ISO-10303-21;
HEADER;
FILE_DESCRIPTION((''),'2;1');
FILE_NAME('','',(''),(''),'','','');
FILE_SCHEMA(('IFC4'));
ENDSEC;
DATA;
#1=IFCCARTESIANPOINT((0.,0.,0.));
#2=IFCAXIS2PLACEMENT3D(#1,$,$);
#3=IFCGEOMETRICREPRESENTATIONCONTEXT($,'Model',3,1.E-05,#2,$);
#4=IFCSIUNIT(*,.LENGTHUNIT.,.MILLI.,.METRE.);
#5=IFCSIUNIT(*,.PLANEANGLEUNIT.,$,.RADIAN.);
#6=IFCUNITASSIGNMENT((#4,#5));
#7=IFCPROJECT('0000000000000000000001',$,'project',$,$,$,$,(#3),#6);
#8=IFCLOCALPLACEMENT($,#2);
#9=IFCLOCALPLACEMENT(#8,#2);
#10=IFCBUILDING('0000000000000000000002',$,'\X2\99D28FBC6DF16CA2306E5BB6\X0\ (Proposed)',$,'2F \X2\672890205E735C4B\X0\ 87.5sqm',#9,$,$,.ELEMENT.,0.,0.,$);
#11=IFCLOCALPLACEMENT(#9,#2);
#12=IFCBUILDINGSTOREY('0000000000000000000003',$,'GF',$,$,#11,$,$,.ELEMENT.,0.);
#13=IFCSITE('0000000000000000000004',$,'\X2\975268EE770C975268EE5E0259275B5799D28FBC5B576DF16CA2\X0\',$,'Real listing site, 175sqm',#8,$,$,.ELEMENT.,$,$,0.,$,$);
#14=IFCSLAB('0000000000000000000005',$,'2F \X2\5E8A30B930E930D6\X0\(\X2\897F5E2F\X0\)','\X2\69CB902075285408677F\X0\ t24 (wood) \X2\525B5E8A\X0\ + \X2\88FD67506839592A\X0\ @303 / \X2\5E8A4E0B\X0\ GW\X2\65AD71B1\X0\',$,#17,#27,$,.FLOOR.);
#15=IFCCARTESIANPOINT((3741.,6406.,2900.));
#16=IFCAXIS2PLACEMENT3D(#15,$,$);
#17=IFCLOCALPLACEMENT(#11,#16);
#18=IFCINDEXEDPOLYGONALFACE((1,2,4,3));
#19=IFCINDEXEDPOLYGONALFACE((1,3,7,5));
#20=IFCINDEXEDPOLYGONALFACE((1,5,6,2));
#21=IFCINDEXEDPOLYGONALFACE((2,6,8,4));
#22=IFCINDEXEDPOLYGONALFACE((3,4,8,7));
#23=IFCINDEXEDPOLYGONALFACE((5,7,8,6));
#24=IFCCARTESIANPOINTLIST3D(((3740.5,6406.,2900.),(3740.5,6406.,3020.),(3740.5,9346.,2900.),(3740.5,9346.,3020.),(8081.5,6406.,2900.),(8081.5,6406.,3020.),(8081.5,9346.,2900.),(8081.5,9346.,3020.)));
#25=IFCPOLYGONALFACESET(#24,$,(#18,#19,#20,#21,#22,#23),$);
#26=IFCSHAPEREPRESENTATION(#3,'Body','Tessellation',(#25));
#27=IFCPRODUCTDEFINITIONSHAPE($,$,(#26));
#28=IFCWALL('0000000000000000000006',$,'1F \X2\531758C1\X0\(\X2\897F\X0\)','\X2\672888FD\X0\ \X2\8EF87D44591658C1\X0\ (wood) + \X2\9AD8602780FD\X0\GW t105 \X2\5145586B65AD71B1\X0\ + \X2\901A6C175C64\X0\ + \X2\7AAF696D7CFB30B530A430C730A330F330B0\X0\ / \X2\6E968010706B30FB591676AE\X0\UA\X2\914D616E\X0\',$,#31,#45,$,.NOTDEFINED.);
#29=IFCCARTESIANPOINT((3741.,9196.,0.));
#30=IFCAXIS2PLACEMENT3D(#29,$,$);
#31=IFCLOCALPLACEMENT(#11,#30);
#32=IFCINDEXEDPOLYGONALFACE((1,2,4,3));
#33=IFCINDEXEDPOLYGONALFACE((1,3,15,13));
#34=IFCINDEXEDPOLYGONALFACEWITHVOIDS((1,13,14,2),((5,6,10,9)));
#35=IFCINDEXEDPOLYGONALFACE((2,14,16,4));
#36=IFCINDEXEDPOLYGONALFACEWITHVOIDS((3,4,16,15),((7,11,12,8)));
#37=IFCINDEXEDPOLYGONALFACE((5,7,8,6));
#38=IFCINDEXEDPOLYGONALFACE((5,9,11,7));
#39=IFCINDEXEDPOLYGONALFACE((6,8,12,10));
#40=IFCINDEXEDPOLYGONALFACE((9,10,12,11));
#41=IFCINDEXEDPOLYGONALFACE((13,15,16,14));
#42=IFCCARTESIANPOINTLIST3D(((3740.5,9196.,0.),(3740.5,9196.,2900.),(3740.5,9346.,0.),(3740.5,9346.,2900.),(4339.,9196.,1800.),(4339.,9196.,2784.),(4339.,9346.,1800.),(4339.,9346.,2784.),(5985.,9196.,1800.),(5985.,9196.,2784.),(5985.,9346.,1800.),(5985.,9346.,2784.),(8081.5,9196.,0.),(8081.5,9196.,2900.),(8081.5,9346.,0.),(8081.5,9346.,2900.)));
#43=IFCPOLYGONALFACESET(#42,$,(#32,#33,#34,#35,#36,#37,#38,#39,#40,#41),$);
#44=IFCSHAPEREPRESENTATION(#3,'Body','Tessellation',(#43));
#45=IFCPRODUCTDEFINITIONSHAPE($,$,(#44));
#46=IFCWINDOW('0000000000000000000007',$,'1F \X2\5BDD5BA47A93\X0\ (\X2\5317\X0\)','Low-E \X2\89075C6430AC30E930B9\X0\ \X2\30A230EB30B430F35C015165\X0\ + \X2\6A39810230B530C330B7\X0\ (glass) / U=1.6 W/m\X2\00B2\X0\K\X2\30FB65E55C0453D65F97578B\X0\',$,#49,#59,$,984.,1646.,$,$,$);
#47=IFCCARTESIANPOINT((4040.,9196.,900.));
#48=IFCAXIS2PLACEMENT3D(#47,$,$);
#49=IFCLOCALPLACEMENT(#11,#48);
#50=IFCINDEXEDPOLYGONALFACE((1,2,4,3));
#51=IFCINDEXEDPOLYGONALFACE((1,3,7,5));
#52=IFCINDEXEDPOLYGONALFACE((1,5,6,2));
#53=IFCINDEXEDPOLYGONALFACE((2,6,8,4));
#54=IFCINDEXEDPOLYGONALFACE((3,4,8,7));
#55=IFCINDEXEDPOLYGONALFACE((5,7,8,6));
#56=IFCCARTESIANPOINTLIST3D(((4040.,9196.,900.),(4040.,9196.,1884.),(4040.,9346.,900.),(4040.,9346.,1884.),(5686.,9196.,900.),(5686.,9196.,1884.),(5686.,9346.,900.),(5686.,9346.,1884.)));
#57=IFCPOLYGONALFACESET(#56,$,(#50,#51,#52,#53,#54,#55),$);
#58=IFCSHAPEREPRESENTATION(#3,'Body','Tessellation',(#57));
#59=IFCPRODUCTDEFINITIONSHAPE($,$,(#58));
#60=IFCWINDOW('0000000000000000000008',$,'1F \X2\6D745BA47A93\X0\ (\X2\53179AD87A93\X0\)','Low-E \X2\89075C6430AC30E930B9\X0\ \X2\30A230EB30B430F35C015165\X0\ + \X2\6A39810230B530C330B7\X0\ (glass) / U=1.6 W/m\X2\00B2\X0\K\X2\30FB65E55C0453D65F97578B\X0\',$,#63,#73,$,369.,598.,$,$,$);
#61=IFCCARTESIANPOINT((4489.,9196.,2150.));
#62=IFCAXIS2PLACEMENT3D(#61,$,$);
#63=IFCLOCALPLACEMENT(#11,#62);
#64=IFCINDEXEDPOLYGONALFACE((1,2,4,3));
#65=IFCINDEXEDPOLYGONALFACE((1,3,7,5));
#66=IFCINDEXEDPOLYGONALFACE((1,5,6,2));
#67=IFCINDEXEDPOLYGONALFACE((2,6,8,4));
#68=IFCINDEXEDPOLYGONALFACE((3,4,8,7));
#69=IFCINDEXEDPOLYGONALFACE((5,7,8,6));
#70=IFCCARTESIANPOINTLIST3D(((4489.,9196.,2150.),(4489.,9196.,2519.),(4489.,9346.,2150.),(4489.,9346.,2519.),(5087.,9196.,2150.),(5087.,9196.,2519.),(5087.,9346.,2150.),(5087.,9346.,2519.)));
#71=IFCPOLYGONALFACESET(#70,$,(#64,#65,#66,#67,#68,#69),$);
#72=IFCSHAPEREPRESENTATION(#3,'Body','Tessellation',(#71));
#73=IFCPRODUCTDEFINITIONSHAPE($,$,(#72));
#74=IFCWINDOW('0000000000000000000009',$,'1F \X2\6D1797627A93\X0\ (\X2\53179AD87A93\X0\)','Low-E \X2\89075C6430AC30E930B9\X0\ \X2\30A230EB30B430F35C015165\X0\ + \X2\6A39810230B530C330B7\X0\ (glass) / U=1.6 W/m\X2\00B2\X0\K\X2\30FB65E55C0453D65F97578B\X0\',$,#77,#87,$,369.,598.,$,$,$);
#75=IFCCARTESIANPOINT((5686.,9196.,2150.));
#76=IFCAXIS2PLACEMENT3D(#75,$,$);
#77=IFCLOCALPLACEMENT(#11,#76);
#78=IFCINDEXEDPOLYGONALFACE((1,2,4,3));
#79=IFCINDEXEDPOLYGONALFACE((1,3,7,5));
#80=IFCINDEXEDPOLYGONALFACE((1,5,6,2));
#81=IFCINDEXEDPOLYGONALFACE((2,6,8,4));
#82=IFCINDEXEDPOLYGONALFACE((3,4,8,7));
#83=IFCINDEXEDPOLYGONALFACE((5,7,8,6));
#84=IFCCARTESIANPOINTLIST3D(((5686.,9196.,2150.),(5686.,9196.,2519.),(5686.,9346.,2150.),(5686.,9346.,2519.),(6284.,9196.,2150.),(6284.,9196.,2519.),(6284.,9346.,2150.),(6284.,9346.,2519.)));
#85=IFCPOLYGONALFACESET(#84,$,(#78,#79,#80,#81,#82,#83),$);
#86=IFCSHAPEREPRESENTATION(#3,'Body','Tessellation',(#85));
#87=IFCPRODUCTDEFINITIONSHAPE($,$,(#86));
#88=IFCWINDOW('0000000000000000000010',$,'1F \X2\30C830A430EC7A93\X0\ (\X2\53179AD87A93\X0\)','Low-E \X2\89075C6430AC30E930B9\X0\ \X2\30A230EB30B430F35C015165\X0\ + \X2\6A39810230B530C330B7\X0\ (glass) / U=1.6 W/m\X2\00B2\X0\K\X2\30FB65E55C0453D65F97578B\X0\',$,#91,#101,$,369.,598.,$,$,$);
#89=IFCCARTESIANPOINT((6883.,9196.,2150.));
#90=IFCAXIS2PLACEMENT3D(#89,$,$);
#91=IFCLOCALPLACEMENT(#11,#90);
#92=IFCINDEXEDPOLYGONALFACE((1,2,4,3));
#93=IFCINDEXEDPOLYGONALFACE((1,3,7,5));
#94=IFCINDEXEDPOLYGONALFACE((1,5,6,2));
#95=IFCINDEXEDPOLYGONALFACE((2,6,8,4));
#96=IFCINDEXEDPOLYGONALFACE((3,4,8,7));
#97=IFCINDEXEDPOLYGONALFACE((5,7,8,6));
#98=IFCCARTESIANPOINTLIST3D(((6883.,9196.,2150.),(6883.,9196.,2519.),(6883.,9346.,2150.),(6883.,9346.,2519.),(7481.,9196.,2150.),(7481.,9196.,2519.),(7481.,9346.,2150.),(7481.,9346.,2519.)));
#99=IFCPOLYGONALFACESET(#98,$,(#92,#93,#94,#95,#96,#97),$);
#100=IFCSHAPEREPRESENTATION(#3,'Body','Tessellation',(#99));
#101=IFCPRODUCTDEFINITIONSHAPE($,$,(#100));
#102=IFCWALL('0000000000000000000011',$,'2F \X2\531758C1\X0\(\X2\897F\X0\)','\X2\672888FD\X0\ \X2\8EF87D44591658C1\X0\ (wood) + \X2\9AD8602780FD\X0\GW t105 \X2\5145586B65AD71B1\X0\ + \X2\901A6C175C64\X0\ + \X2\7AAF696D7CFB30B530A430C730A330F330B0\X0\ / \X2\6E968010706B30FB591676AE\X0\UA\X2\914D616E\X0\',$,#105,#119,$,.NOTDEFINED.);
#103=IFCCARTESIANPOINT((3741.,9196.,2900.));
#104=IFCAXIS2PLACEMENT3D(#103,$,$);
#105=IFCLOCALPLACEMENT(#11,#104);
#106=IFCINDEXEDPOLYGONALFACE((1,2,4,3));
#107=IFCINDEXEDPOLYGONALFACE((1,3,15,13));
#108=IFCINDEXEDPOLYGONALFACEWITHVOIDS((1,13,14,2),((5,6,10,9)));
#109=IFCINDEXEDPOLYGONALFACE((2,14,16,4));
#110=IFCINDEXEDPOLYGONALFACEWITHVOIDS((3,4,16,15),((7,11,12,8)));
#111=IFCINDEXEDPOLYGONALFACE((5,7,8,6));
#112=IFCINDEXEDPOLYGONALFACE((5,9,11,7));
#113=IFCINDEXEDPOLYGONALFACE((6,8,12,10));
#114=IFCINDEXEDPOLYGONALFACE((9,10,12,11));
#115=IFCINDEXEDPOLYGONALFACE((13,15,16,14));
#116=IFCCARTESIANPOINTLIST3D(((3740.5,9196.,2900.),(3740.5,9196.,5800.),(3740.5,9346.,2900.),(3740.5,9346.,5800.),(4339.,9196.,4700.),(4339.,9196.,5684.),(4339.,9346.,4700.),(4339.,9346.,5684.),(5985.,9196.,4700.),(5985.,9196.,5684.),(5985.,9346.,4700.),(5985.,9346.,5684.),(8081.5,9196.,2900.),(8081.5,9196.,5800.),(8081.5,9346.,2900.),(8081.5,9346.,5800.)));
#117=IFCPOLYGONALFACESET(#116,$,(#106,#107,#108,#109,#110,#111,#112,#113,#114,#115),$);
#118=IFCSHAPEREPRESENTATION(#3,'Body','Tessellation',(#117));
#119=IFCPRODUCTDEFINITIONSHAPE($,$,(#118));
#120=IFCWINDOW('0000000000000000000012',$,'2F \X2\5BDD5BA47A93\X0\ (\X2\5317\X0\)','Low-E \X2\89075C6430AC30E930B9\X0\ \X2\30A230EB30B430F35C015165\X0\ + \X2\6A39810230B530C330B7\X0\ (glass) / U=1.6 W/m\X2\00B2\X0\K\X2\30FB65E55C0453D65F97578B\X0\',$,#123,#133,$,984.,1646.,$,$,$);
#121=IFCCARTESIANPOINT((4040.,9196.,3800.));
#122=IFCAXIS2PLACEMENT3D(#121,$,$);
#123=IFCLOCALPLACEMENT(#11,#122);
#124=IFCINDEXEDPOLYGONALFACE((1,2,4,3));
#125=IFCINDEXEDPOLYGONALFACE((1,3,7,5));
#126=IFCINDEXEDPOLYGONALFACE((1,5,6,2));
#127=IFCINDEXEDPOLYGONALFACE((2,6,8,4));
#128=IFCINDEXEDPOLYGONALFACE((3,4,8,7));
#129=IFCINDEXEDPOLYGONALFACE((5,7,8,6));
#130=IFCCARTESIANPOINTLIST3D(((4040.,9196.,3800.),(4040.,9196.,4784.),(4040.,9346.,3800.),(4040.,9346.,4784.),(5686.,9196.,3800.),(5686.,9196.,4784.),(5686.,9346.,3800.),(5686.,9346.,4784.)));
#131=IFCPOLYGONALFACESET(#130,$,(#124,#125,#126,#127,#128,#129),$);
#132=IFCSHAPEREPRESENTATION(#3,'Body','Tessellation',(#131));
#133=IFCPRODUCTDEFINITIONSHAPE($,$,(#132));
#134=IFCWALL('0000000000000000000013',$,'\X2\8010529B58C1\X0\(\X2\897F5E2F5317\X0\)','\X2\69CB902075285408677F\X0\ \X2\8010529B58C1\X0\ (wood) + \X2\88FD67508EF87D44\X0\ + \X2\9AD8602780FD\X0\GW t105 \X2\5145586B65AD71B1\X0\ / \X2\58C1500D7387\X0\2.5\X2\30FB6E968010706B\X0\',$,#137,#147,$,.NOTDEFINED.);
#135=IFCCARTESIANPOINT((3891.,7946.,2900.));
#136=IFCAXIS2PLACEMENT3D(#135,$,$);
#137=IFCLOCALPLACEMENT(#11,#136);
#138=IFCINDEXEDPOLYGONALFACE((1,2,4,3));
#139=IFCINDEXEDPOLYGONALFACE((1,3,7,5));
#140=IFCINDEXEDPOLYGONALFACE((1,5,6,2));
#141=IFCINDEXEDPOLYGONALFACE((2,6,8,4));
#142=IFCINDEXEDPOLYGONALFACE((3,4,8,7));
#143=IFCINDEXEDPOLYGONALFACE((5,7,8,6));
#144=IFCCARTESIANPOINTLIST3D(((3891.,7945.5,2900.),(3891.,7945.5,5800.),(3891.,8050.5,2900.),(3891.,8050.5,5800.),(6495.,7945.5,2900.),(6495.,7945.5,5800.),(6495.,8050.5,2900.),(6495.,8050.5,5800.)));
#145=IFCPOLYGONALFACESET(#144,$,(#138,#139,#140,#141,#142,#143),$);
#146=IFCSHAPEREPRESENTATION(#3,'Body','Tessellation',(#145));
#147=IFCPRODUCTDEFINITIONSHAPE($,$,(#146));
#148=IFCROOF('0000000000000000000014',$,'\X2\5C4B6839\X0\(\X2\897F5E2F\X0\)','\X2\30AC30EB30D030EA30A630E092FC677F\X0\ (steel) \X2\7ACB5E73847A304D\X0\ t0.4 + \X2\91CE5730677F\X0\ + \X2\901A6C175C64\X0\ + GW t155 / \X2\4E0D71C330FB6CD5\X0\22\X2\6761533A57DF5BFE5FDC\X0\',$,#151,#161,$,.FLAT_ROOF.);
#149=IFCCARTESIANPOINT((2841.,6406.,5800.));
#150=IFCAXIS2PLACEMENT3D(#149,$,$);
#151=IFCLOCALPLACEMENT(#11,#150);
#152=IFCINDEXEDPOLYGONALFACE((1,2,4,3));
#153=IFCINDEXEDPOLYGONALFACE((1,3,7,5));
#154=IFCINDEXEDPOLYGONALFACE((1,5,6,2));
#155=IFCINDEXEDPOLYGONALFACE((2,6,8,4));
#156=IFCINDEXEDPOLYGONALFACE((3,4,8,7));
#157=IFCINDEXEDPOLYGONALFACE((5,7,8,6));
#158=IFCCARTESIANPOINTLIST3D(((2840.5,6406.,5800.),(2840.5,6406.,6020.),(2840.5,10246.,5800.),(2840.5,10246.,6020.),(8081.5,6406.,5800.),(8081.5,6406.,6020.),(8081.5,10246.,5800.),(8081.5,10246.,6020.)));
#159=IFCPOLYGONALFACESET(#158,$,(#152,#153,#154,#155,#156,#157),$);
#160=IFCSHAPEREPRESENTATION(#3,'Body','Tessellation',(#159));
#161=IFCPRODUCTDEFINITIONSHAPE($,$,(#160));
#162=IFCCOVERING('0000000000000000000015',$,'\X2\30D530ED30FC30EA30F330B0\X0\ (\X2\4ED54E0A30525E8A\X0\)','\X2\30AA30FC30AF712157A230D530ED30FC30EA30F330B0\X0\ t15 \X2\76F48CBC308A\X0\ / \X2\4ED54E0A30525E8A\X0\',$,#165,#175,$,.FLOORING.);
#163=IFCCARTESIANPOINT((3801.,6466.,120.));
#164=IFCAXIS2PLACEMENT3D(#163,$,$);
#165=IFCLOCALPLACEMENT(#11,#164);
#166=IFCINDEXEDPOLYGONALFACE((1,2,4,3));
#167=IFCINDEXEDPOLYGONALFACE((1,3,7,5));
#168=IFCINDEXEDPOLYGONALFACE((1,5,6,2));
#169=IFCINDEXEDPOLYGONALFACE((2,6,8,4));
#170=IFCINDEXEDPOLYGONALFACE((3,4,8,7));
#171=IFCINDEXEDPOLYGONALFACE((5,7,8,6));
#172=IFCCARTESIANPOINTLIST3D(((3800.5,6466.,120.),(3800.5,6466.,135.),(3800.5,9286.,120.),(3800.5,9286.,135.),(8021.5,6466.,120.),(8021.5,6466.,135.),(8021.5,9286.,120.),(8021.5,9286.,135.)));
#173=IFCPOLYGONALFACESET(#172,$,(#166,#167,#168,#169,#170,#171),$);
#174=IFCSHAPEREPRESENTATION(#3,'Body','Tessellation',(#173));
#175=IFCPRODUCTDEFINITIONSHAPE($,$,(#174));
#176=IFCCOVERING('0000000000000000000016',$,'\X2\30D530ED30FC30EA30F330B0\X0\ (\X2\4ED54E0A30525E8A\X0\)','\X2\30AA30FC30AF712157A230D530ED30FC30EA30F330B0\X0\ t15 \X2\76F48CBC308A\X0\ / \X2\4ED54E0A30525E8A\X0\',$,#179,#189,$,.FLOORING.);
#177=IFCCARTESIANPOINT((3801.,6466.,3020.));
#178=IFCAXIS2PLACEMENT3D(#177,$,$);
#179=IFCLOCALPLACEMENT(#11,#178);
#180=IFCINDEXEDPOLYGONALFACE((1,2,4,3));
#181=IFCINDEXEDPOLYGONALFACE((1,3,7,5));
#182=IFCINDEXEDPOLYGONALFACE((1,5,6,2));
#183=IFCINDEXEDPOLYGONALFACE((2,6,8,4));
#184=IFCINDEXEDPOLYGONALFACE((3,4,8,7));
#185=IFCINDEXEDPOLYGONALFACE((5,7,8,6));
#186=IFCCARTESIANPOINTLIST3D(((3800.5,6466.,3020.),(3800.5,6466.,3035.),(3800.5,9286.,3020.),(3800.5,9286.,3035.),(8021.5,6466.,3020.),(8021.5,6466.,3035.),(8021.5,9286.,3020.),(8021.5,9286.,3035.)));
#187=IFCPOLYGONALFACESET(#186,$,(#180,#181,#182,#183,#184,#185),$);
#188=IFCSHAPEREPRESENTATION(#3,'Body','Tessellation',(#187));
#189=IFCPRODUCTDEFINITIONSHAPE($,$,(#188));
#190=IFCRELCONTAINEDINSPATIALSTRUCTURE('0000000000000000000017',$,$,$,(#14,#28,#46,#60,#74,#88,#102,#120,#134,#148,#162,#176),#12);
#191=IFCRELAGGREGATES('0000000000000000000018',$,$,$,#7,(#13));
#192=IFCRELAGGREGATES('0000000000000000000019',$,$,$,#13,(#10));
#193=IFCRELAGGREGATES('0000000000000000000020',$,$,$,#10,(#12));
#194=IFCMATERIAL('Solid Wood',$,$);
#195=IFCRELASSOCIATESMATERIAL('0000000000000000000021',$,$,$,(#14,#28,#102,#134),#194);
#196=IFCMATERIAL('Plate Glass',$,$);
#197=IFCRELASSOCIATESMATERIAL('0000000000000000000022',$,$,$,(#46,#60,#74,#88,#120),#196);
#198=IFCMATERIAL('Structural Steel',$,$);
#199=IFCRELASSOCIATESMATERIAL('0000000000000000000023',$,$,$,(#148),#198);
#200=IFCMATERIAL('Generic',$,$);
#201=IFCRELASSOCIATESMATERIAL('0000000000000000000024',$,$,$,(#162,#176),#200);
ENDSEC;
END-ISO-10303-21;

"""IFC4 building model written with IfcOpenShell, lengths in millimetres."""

from ifc_helpers import new_model, si_unit, frame, frame_2d, origin, place, context, project, spatial, rectangle, extrude, material, element, fill, save


model = new_model("IFC4")

# Units and contexts
model_context = context("Model", 3, precision=1e-05, world=origin())
ifc_project = project(units=[si_unit("LENGTHUNIT", "METRE", prefix="MILLI"), si_unit("PLANEANGLEUNIT", "RADIAN")], contexts=[model_context])

# Site, building, storey
site_placement = place(None, origin())
site = spatial("IfcSite", under=ifc_project, at=site_placement, Name="青森県青森市大字駒込字深沢", ObjectType="Real listing site, 175sqm", CompositionType="ELEMENT", RefElevation=0.0)
building_placement = place(site_placement, origin())
building = spatial("IfcBuilding", under=site, at=building_placement, Name="駒込深沢の家 (Proposed)", ObjectType="2F 木造平屋 87.5sqm", CompositionType="ELEMENT", ElevationOfRefHeight=0.0, ElevationOfTerrain=0.0)
storey_placement = place(building_placement, origin())
storey = spatial("IfcBuildingStorey", under=building, at=storey_placement, Name="GF", CompositionType="ELEMENT", Elevation=0.0)

# Slab
ifc_material_1 = material(Name="Solid Wood")
slab_1_placement = place(storey_placement, frame((3741.0, 6406.0, 2900.0)))
element("IfcSlab", 1, at=slab_1_placement, inside=storey, material=ifc_material_1, Name="2F 床スラブ(西帯)", Description="構造用合板 t24 (wood) 剛床 + 製材根太 @303 / 床下 GW断熱", PredefinedType="FLOOR", context=model_context, shape_type="SweptSolid", body=[
    extrude(rectangle(XDim=4341.0, YDim=2940.0, at=frame_2d((2170.0, 1470.0))), frame((3741.0, 6406.0, 2900.0)), (0.0, 0.0, 1.0), 120.0),
])

# Wall, openings, windows
wall_1_placement = place(storey_placement, frame((3741.0, 9196.0, 0.0)))
wall_1 = element("IfcWall", 2, at=wall_1_placement, inside=storey, material=ifc_material_1, Name="1F 北壁(西)", Description="木製 軸組外壁 (wood) + 高性能GW t105 充填断熱 + 通気層 + 窯業系サイディング / 準耐火・外皮UA配慮", PredefinedType="NOTDEFINED", context=model_context, shape_type="SweptSolid", body=[
    extrude(rectangle(XDim=4341.0, YDim=150.0, at=frame_2d((2170.0, 75.0))), frame((3741.0, 9196.0, 0.0)), (0.0, 0.0, 1.0), 2900.0),
])
opening_1_placement = place(storey_placement, frame((4040.0, 9196.0, 900.0)))
opening_1 = element("IfcOpeningElement", 3, at=opening_1_placement, cuts=wall_1, PredefinedType="NOTDEFINED", context=model_context, shape_type="SweptSolid", body=[
    extrude(rectangle(XDim=1646.0, YDim=150.0, at=frame_2d((823.0, 75.0))), frame((4040.0, 9196.0, 900.0)), (0.0, 0.0, 1.0), 984.0),
])
opening_2_placement = place(storey_placement, frame((4489.0, 9196.0, 2150.0)))
opening_2 = element("IfcOpeningElement", 4, at=opening_2_placement, cuts=wall_1, PredefinedType="NOTDEFINED", context=model_context, shape_type="SweptSolid", body=[
    extrude(rectangle(XDim=598.0, YDim=150.0, at=frame_2d((299.0, 75.0))), frame((4489.0, 9196.0, 2150.0)), (0.0, 0.0, 1.0), 369.0),
])
opening_3_placement = place(storey_placement, frame((5686.0, 9196.0, 2150.0)))
opening_3 = element("IfcOpeningElement", 5, at=opening_3_placement, cuts=wall_1, PredefinedType="NOTDEFINED", context=model_context, shape_type="SweptSolid", body=[
    extrude(rectangle(XDim=598.0, YDim=150.0, at=frame_2d((299.0, 75.0))), frame((5686.0, 9196.0, 2150.0)), (0.0, 0.0, 1.0), 369.0),
])
opening_4_placement = place(storey_placement, frame((6883.0, 9196.0, 2150.0)))
opening_4 = element("IfcOpeningElement", 6, at=opening_4_placement, cuts=wall_1, PredefinedType="NOTDEFINED", context=model_context, shape_type="SweptSolid", body=[
    extrude(rectangle(XDim=598.0, YDim=150.0, at=frame_2d((299.0, 75.0))), frame((6883.0, 9196.0, 2150.0)), (0.0, 0.0, 1.0), 369.0),
])
ifc_material_2 = material(Name="Plate Glass")
window_1_placement = place(storey_placement, frame((4040.0, 9196.0, 900.0)))
window_1 = element("IfcWindow", 7, at=window_1_placement, inside=storey, material=ifc_material_2, Name="1F 寝室窓 (北)", Description="Low-E 複層ガラス アルゴン封入 + 樹脂サッシ (glass) / U=1.6 W/m²K・日射取得型", OverallHeight=984.0, OverallWidth=1646.0, context=model_context, shape_type="SweptSolid", body=[
    extrude(rectangle(XDim=1646.0, YDim=150.0, at=frame_2d((823.0, 75.0))), frame((4040.0, 9196.0, 900.0)), (0.0, 0.0, 1.0), 984.0),
])
fill(opening_1, window_1)
window_2_placement = place(storey_placement, frame((4489.0, 9196.0, 2150.0)))
window_2 = element("IfcWindow", 8, at=window_2_placement, inside=storey, material=ifc_material_2, Name="1F 浴室窓 (北高窓)", Description="Low-E 複層ガラス アルゴン封入 + 樹脂サッシ (glass) / U=1.6 W/m²K・日射取得型", OverallHeight=369.0, OverallWidth=598.0, context=model_context, shape_type="SweptSolid", body=[
    extrude(rectangle(XDim=598.0, YDim=150.0, at=frame_2d((299.0, 75.0))), frame((4489.0, 9196.0, 2150.0)), (0.0, 0.0, 1.0), 369.0),
])
fill(opening_2, window_2)
window_3_placement = place(storey_placement, frame((5686.0, 9196.0, 2150.0)))
window_3 = element("IfcWindow", 9, at=window_3_placement, inside=storey, material=ifc_material_2, Name="1F 洗面窓 (北高窓)", Description="Low-E 複層ガラス アルゴン封入 + 樹脂サッシ (glass) / U=1.6 W/m²K・日射取得型", OverallHeight=369.0, OverallWidth=598.0, context=model_context, shape_type="SweptSolid", body=[
    extrude(rectangle(XDim=598.0, YDim=150.0, at=frame_2d((299.0, 75.0))), frame((5686.0, 9196.0, 2150.0)), (0.0, 0.0, 1.0), 369.0),
])
fill(opening_3, window_3)
window_4_placement = place(storey_placement, frame((6883.0, 9196.0, 2150.0)))
window_4 = element("IfcWindow", 10, at=window_4_placement, inside=storey, material=ifc_material_2, Name="1F トイレ窓 (北高窓)", Description="Low-E 複層ガラス アルゴン封入 + 樹脂サッシ (glass) / U=1.6 W/m²K・日射取得型", OverallHeight=369.0, OverallWidth=598.0, context=model_context, shape_type="SweptSolid", body=[
    extrude(rectangle(XDim=598.0, YDim=150.0, at=frame_2d((299.0, 75.0))), frame((6883.0, 9196.0, 2150.0)), (0.0, 0.0, 1.0), 369.0),
])
fill(opening_4, window_4)

# Wall, opening, window
wall_2_placement = place(storey_placement, frame((3741.0, 9196.0, 2900.0)))
wall_2 = element("IfcWall", 11, at=wall_2_placement, inside=storey, material=ifc_material_1, Name="2F 北壁(西)", Description="木製 軸組外壁 (wood) + 高性能GW t105 充填断熱 + 通気層 + 窯業系サイディング / 準耐火・外皮UA配慮", PredefinedType="NOTDEFINED", context=model_context, shape_type="SweptSolid", body=[
    extrude(rectangle(XDim=4341.0, YDim=150.0, at=frame_2d((2170.0, 75.0))), frame((3741.0, 9196.0, 2900.0)), (0.0, 0.0, 1.0), 2900.0),
])
opening_5_placement = place(storey_placement, frame((4040.0, 9196.0, 3800.0)))
opening_5 = element("IfcOpeningElement", 12, at=opening_5_placement, cuts=wall_2, PredefinedType="NOTDEFINED", context=model_context, shape_type="SweptSolid", body=[
    extrude(rectangle(XDim=1646.0, YDim=150.0, at=frame_2d((823.0, 75.0))), frame((4040.0, 9196.0, 3800.0)), (0.0, 0.0, 1.0), 984.0),
])
window_5_placement = place(storey_placement, frame((4040.0, 9196.0, 3800.0)))
window_5 = element("IfcWindow", 13, at=window_5_placement, inside=storey, material=ifc_material_2, Name="2F 寝室窓 (北)", Description="Low-E 複層ガラス アルゴン封入 + 樹脂サッシ (glass) / U=1.6 W/m²K・日射取得型", OverallHeight=984.0, OverallWidth=1646.0, context=model_context, shape_type="SweptSolid", body=[
    extrude(rectangle(XDim=1646.0, YDim=150.0, at=frame_2d((823.0, 75.0))), frame((4040.0, 9196.0, 3800.0)), (0.0, 0.0, 1.0), 984.0),
])
fill(opening_5, window_5)

# Wall
wall_3_placement = place(storey_placement, frame((3891.0, 7946.0, 2900.0)))
element("IfcWall", 14, at=wall_3_placement, inside=storey, material=ifc_material_1, Name="耐力壁(西帯北)", Description="構造用合板 耐力壁 (wood) + 製材軸組 + 高性能GW t105 充填断熱 / 壁倍率2.5・準耐火", PredefinedType="NOTDEFINED", context=model_context, shape_type="SweptSolid", body=[
    extrude(rectangle(XDim=2604.0, YDim=105.0, at=frame_2d((1302.0, 52.0))), frame((3891.0, 7946.0, 2900.0)), (0.0, 0.0, 1.0), 2900.0),
])

# Roof
ifc_material_3 = material(Name="Structural Steel")
for number, where, name in (
    (15, (2841.0, 6406.0, 5800.0), "屋根(西帯)"),
):
    element("IfcRoof", number, at=place(storey_placement, frame(where)), inside=storey, material=ifc_material_3, Name=name, Description="ガルバリウム鋼板 (steel) 立平葺き t0.4 + 野地板 + 通気層 + GW t155 / 不燃・法22条区域対応", PredefinedType="FLAT_ROOF", context=model_context, shape_type="SweptSolid", body=[
        extrude(rectangle(XDim=5241.0, YDim=3840.0, at=frame_2d((2620.0, 1920.0))), frame((2841.0, 6406.0, 5800.0)), (0.0, 0.0, 1.0), 220.0),
    ])

# Coverings
ifc_material_4 = material(Name="Generic")
covering_1_placement = place(storey_placement, frame((3801.0, 6466.0, 120.0)))
element("IfcCovering", 16, at=covering_1_placement, inside=storey, material=ifc_material_4, Name="フローリング (仕上げ床)", Description="オーク無垢フローリング t15 直貼り / 仕上げ床", PredefinedType="FLOORING", context=model_context, shape_type="SweptSolid", body=[
    extrude(rectangle(XDim=4221.0, YDim=2820.0, at=frame_2d((2110.0, 1410.0))), frame((3801.0, 6466.0, 120.0)), (0.0, 0.0, 1.0), 15.0),
])
covering_2_placement = place(storey_placement, frame((3801.0, 6466.0, 3020.0)))
element("IfcCovering", 17, at=covering_2_placement, inside=storey, material=ifc_material_4, Name="フローリング (仕上げ床)", Description="オーク無垢フローリング t15 直貼り / 仕上げ床", PredefinedType="FLOORING", context=model_context, shape_type="SweptSolid", body=[
    extrude(rectangle(XDim=4221.0, YDim=2820.0, at=frame_2d((2110.0, 1410.0))), frame((3801.0, 6466.0, 3020.0)), (0.0, 0.0, 1.0), 15.0),
])

save(model, "model.ifc")
